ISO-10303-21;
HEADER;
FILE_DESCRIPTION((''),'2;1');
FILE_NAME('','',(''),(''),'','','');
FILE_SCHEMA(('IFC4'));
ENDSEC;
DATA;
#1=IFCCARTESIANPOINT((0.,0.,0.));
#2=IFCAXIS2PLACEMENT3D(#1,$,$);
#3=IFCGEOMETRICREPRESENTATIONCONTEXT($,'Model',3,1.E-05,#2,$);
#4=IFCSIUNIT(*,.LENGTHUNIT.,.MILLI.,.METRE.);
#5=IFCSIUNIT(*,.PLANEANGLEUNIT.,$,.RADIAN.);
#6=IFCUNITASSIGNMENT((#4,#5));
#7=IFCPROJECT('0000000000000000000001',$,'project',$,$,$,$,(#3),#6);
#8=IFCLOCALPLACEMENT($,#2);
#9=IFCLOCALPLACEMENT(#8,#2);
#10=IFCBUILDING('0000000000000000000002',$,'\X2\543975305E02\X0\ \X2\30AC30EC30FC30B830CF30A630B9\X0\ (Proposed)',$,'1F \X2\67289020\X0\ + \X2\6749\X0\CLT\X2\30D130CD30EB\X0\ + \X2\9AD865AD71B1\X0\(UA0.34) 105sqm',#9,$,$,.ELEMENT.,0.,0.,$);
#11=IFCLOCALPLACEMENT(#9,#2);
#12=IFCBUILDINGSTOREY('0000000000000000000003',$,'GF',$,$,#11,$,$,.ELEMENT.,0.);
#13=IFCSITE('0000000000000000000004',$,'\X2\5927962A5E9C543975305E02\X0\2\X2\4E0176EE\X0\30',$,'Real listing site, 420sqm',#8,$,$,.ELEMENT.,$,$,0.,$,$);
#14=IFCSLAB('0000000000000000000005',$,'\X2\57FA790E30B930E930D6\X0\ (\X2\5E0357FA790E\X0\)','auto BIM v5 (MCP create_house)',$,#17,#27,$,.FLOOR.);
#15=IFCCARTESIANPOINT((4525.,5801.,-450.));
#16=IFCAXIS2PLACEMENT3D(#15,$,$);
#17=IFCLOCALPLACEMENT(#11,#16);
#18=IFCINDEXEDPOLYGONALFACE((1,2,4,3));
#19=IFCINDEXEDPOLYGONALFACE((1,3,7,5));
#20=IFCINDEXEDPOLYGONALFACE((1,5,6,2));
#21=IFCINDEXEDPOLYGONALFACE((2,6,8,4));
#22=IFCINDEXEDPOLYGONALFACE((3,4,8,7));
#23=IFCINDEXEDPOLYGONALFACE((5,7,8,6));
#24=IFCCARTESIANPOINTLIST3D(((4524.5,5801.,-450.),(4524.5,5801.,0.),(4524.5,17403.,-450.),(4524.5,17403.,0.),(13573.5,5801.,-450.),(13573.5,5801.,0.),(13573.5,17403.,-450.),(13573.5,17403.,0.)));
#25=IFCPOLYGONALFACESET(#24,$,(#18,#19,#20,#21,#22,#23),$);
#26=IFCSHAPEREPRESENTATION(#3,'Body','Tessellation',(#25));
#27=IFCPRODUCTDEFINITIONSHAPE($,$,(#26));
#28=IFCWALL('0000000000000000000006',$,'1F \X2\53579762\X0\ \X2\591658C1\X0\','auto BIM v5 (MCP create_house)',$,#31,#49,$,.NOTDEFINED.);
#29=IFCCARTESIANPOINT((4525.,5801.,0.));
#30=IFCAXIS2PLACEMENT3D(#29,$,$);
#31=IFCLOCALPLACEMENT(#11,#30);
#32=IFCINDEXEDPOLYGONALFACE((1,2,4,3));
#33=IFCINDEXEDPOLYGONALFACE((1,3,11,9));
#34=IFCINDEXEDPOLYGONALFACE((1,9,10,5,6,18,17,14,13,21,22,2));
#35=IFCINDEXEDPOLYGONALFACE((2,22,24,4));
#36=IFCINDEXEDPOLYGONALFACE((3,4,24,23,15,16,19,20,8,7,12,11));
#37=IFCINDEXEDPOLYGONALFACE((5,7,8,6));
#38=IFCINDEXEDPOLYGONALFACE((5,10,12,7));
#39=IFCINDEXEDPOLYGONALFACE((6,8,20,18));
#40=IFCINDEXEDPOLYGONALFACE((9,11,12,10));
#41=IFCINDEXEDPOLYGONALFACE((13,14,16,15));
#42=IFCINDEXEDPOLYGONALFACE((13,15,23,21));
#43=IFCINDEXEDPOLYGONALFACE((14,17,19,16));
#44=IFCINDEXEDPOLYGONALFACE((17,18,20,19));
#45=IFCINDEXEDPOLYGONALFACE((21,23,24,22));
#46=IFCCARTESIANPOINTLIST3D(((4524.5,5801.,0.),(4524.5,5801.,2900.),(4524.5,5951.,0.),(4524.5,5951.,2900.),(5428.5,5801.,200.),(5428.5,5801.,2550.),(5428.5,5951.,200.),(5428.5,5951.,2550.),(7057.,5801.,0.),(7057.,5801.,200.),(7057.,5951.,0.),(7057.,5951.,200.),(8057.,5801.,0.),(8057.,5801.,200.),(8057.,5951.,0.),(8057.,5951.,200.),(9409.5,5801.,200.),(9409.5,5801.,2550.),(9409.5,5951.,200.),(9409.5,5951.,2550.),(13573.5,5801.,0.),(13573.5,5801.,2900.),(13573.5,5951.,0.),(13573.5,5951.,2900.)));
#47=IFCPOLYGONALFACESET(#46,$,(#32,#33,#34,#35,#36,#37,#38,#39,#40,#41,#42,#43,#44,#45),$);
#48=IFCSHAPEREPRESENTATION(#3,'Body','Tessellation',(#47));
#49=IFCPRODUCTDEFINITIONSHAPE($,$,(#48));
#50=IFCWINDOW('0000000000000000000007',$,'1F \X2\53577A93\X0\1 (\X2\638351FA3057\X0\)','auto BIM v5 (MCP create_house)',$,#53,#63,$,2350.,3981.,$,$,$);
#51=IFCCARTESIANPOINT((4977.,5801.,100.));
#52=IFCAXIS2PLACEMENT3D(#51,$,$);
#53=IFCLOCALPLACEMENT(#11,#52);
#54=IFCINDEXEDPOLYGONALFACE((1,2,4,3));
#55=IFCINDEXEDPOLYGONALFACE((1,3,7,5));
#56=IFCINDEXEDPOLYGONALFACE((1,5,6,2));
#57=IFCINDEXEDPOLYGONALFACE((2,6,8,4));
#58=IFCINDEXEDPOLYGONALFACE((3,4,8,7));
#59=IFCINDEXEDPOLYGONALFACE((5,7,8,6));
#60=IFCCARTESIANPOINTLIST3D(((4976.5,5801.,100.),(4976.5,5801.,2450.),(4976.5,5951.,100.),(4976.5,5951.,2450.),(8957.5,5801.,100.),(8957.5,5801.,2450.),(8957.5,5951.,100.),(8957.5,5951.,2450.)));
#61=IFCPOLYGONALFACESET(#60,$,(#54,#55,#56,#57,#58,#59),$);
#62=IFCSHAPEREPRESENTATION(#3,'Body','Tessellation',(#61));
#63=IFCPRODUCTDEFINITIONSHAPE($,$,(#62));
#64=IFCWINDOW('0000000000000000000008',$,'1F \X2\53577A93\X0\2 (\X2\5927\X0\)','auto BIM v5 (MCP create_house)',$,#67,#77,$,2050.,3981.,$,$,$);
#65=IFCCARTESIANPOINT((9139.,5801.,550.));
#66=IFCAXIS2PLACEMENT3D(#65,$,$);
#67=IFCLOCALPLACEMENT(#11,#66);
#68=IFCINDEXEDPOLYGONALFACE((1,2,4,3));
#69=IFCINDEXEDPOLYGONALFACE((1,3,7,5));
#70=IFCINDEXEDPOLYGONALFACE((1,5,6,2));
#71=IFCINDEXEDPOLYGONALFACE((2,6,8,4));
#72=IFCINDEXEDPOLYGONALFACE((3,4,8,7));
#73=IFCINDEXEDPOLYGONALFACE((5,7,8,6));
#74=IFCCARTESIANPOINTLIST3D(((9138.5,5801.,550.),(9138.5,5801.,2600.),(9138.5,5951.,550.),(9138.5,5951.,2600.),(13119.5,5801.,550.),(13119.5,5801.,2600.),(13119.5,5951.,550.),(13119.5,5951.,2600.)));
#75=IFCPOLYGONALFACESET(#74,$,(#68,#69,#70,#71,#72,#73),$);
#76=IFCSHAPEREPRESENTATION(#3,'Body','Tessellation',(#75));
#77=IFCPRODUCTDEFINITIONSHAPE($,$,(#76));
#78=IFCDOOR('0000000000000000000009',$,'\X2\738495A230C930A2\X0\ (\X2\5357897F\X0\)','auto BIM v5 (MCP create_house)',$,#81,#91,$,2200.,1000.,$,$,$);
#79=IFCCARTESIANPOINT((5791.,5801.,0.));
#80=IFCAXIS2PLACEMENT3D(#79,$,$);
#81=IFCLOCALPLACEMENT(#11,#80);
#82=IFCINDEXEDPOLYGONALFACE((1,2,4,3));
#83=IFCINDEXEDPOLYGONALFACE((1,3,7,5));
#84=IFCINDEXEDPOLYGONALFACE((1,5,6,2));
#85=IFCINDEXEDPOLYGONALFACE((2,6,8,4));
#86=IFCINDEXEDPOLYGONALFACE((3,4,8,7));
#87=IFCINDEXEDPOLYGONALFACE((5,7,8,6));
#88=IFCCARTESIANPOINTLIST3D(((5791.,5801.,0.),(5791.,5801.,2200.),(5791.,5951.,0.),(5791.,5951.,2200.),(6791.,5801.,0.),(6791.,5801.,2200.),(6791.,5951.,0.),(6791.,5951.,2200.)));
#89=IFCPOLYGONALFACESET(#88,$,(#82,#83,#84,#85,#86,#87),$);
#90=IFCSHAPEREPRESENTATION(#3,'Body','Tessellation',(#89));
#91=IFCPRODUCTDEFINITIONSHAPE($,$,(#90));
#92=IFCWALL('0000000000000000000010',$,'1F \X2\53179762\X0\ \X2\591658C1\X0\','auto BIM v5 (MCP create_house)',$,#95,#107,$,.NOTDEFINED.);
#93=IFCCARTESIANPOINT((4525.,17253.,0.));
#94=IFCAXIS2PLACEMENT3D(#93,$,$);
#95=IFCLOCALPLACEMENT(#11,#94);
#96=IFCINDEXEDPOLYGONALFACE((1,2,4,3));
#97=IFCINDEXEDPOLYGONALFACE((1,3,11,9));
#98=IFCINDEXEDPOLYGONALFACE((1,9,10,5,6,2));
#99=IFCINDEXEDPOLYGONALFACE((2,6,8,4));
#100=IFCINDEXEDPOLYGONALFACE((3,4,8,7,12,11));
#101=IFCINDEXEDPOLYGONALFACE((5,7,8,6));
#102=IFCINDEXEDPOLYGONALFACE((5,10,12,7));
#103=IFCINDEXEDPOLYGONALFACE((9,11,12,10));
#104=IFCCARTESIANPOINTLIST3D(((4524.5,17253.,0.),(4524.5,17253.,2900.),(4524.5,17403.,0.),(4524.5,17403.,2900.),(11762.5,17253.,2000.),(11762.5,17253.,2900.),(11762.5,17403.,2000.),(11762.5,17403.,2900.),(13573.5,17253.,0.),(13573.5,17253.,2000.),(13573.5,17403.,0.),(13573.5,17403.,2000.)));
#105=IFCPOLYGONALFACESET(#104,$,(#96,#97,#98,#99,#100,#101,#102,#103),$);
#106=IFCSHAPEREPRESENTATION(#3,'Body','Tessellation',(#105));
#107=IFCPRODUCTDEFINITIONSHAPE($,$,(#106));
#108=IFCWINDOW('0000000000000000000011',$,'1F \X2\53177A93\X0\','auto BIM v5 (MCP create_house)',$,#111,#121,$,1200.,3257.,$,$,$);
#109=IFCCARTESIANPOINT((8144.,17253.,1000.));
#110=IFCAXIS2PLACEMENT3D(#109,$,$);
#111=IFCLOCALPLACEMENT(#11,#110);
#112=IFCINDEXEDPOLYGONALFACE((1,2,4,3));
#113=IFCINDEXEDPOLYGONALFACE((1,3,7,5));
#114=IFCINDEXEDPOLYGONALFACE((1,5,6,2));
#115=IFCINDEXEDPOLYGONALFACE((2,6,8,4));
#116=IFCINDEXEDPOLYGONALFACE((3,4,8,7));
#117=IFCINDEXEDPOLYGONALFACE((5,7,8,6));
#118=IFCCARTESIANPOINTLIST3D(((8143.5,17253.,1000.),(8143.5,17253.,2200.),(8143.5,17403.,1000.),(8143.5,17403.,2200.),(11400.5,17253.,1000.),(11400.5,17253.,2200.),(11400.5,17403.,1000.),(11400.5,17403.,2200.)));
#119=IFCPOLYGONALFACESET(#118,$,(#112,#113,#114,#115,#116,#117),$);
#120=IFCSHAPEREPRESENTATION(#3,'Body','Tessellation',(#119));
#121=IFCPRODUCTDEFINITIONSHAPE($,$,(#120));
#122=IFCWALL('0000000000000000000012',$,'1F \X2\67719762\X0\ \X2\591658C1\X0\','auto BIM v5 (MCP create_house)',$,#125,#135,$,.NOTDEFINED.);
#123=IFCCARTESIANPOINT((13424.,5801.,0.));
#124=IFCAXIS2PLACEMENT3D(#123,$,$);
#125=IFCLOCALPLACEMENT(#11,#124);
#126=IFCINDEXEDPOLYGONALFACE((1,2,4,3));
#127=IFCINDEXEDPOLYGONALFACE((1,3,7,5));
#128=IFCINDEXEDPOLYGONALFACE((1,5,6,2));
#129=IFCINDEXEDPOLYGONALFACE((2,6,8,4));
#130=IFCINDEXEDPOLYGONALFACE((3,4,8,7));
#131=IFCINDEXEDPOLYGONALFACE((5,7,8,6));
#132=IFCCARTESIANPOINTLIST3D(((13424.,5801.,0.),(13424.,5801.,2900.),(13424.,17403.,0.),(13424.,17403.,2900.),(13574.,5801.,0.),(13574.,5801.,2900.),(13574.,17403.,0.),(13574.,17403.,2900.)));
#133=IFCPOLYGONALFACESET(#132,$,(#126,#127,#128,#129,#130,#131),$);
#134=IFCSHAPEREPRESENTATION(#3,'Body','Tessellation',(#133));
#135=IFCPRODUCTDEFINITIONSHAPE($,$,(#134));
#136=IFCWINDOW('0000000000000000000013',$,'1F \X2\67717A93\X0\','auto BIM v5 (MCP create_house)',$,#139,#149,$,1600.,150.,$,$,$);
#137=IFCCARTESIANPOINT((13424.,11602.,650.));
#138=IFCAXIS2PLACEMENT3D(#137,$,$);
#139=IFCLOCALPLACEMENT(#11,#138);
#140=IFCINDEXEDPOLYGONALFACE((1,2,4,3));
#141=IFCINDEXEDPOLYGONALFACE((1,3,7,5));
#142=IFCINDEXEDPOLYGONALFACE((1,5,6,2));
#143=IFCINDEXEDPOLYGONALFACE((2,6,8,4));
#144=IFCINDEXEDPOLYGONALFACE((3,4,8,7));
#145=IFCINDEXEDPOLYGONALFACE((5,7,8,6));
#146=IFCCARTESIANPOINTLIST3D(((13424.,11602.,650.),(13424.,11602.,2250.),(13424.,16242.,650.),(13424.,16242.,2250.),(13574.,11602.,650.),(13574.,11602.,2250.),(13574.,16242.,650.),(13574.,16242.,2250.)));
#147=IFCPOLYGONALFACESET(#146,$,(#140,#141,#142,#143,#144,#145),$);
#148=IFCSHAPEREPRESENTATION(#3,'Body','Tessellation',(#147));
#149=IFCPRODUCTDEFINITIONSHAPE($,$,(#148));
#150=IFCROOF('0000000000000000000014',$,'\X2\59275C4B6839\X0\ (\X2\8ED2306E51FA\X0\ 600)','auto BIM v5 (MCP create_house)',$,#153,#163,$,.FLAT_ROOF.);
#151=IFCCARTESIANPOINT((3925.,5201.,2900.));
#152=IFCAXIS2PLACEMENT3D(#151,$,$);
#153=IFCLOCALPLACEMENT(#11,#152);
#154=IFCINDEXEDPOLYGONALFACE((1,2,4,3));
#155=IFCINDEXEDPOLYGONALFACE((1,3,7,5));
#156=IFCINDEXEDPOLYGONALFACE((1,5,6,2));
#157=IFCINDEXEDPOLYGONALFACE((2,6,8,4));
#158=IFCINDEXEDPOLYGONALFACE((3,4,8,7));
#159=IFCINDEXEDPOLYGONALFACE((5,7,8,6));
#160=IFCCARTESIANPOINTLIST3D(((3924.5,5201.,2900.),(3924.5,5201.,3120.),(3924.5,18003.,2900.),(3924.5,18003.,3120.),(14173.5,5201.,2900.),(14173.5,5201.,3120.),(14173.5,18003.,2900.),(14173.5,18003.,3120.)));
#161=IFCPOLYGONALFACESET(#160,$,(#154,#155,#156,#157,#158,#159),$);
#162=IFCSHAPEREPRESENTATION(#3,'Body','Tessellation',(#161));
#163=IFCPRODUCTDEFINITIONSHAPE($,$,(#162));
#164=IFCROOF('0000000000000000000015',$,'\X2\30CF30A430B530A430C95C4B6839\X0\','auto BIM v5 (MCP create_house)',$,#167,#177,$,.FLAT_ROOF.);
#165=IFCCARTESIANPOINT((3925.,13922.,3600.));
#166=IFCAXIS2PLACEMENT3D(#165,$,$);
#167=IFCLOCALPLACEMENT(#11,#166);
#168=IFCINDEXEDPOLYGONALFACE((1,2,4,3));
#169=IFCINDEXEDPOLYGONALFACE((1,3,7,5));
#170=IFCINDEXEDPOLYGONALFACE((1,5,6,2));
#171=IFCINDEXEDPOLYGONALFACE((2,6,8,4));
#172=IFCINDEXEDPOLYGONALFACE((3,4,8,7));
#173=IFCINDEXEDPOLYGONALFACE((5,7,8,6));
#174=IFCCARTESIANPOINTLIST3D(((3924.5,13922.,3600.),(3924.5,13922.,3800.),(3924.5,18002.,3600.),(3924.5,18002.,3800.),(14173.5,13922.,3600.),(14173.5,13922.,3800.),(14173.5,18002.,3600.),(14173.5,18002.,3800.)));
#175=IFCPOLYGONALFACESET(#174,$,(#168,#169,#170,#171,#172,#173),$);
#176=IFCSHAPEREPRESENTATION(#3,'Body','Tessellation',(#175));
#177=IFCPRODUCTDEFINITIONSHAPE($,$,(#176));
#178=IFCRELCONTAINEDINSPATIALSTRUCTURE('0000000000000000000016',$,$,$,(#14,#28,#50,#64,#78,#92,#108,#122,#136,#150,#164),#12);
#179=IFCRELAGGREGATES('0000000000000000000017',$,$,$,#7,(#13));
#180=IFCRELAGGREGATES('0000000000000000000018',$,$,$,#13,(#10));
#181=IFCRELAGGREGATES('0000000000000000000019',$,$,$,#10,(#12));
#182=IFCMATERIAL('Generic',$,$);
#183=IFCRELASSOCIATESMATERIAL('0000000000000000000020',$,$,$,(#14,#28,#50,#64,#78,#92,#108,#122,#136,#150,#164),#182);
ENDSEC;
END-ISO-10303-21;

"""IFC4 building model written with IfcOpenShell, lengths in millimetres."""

from ifc_helpers import new_model, si_unit, frame, frame_2d, origin, place, context, project, spatial, rectangle, extrude, material, element, fill, save


model = new_model("IFC4")

# Units and contexts
model_context = context("Model", 3, precision=1e-05, world=origin())
ifc_project = project(units=[si_unit("LENGTHUNIT", "METRE", prefix="MILLI"), si_unit("PLANEANGLEUNIT", "RADIAN")], contexts=[model_context])

# Site, building, storey
site_placement = place(None, origin())
site = spatial("IfcSite", under=ifc_project, at=site_placement, Name="大阪府吹田市2丁目30", ObjectType="Real listing site, 420sqm", CompositionType="ELEMENT", RefElevation=0.0)
building_placement = place(site_placement, origin())
building = spatial("IfcBuilding", under=site, at=building_placement, Name="吹田市 ガレージハウス (Proposed)", ObjectType="1F 木造 + 杉CLTパネル + 高断熱(UA0.34) 105sqm", CompositionType="ELEMENT", ElevationOfRefHeight=0.0, ElevationOfTerrain=0.0)
storey_placement = place(building_placement, origin())
storey = spatial("IfcBuildingStorey", under=building, at=storey_placement, Name="GF", CompositionType="ELEMENT", Elevation=0.0)

# Slab
ifc_material = material(Name="Generic")
slab_1_placement = place(storey_placement, frame((4525.0, 5801.0, -450.0)))
element("IfcSlab", 1, at=slab_1_placement, inside=storey, material=ifc_material, Name="基礎スラブ (布基礎)", Description="auto BIM v5 (MCP create_house)", PredefinedType="FLOOR", context=model_context, shape_type="SweptSolid", body=[
    extrude(rectangle(XDim=9049.0, YDim=11602.0, at=frame_2d((4524.0, 5801.0))), frame((4525.0, 5801.0, -450.0)), (0.0, 0.0, 1.0), 450.0),
])

# Wall, openings, windows, door
wall_1_placement = place(storey_placement, frame((4525.0, 5801.0, 0.0)))
wall_1 = element("IfcWall", 2, at=wall_1_placement, inside=storey, material=ifc_material, Name="1F 南面 外壁", Description="auto BIM v5 (MCP create_house)", PredefinedType="NOTDEFINED", context=model_context, shape_type="SweptSolid", body=[
    extrude(rectangle(XDim=9049.0, YDim=150.0, at=frame_2d((4524.0, 75.0))), frame((4525.0, 5801.0, 0.0)), (0.0, 0.0, 1.0), 2900.0),
])
opening_1_placement = place(storey_placement, frame((4977.0, 5801.0, 100.0)))
opening_1 = element("IfcOpeningElement", 3, at=opening_1_placement, cuts=wall_1, PredefinedType="NOTDEFINED", context=model_context, shape_type="SweptSolid", body=[
    extrude(rectangle(XDim=3981.0, YDim=150.0, at=frame_2d((1990.0, 75.0))), frame((4977.0, 5801.0, 100.0)), (0.0, 0.0, 1.0), 2350.0),
])
opening_2_placement = place(storey_placement, frame((9139.0, 5801.0, 550.0)))
opening_2 = element("IfcOpeningElement", 4, at=opening_2_placement, cuts=wall_1, PredefinedType="NOTDEFINED", context=model_context, shape_type="SweptSolid", body=[
    extrude(rectangle(XDim=3981.0, YDim=150.0, at=frame_2d((1990.0, 75.0))), frame((9139.0, 5801.0, 550.0)), (0.0, 0.0, 1.0), 2050.0),
])
opening_3_placement = place(storey_placement, frame((5791.0, 5801.0, 0.0)))
opening_3 = element("IfcOpeningElement", 5, at=opening_3_placement, cuts=wall_1, PredefinedType="NOTDEFINED", context=model_context, shape_type="SweptSolid", body=[
    extrude(rectangle(XDim=1000.0, YDim=150.0, at=frame_2d((500.0, 75.0))), frame((5791.0, 5801.0, 0.0)), (0.0, 0.0, 1.0), 2200.0),
])
window_1_placement = place(storey_placement, frame((4977.0, 5801.0, 100.0)))
window_1 = element("IfcWindow", 6, at=window_1_placement, inside=storey, material=ifc_material, Name="1F 南窓1 (掃出し)", Description="auto BIM v5 (MCP create_house)", OverallHeight=2350.0, OverallWidth=3981.0, context=model_context, shape_type="SweptSolid", body=[
    extrude(rectangle(XDim=3981.0, YDim=150.0, at=frame_2d((1990.0, 75.0))), frame((4977.0, 5801.0, 100.0)), (0.0, 0.0, 1.0), 2350.0),
])
fill(opening_1, window_1)
window_2_placement = place(storey_placement, frame((9139.0, 5801.0, 550.0)))
window_2 = element("IfcWindow", 7, at=window_2_placement, inside=storey, material=ifc_material, Name="1F 南窓2 (大)", Description="auto BIM v5 (MCP create_house)", OverallHeight=2050.0, OverallWidth=3981.0, context=model_context, shape_type="SweptSolid", body=[
    extrude(rectangle(XDim=3981.0, YDim=150.0, at=frame_2d((1990.0, 75.0))), frame((9139.0, 5801.0, 550.0)), (0.0, 0.0, 1.0), 2050.0),
])
fill(opening_2, window_2)
door_placement = place(storey_placement, frame((5791.0, 5801.0, 0.0)))
door = element("IfcDoor", 8, at=door_placement, inside=storey, material=ifc_material, Name="玄関ドア (南西)", Description="auto BIM v5 (MCP create_house)", OverallHeight=2200.0, OverallWidth=1000.0, context=model_context, shape_type="SweptSolid", body=[
    extrude(rectangle(XDim=1000.0, YDim=150.0, at=frame_2d((500.0, 75.0))), frame((5791.0, 5801.0, 0.0)), (0.0, 0.0, 1.0), 2200.0),
])
fill(opening_3, door)

# Walls, openings, windows
wall_2_placement = place(storey_placement, frame((4525.0, 17253.0, 0.0)))
wall_2 = element("IfcWall", 9, at=wall_2_placement, inside=storey, material=ifc_material, Name="1F 北面 外壁", Description="auto BIM v5 (MCP create_house)", PredefinedType="NOTDEFINED", context=model_context, shape_type="SweptSolid", body=[
    extrude(rectangle(XDim=9049.0, YDim=150.0, at=frame_2d((4524.0, 75.0))), frame((4525.0, 17253.0, 0.0)), (0.0, 0.0, 1.0), 2900.0),
])
opening_4_placement = place(storey_placement, frame((8144.0, 17253.0, 1000.0)))
opening_4 = element("IfcOpeningElement", 10, at=opening_4_placement, cuts=wall_2, PredefinedType="NOTDEFINED", context=model_context, shape_type="SweptSolid", body=[
    extrude(rectangle(XDim=3257.0, YDim=150.0, at=frame_2d((1628.0, 75.0))), frame((8144.0, 17253.0, 1000.0)), (0.0, 0.0, 1.0), 1200.0),
])
window_3_placement = place(storey_placement, frame((8144.0, 17253.0, 1000.0)))
window_3 = element("IfcWindow", 11, at=window_3_placement, inside=storey, material=ifc_material, Name="1F 北窓", Description="auto BIM v5 (MCP create_house)", OverallHeight=1200.0, OverallWidth=3257.0, context=model_context, shape_type="SweptSolid", body=[
    extrude(rectangle(XDim=3257.0, YDim=150.0, at=frame_2d((1628.0, 75.0))), frame((8144.0, 17253.0, 1000.0)), (0.0, 0.0, 1.0), 1200.0),
])
fill(opening_4, window_3)
wall_3_placement = place(storey_placement, frame((13424.0, 5801.0, 0.0)))
wall_3 = element("IfcWall", 12, at=wall_3_placement, inside=storey, material=ifc_material, Name="1F 東面 外壁", Description="auto BIM v5 (MCP create_house)", PredefinedType="NOTDEFINED", context=model_context, shape_type="SweptSolid", body=[
    extrude(rectangle(XDim=150.0, YDim=11602.0, at=frame_2d((75.0, 5801.0))), frame((13424.0, 5801.0, 0.0)), (0.0, 0.0, 1.0), 2900.0),
])
opening_5_placement = place(storey_placement, frame((13424.0, 11602.0, 650.0)))
opening_5 = element("IfcOpeningElement", 13, at=opening_5_placement, cuts=wall_3, PredefinedType="NOTDEFINED", context=model_context, shape_type="SweptSolid", body=[
    extrude(rectangle(XDim=150.0, YDim=4640.0, at=frame_2d((75.0, 2320.0))), frame((13424.0, 11602.0, 650.0)), (0.0, 0.0, 1.0), 1600.0),
])
window_4_placement = place(storey_placement, frame((13424.0, 11602.0, 650.0)))
window_4 = element("IfcWindow", 14, at=window_4_placement, inside=storey, material=ifc_material, Name="1F 東窓", Description="auto BIM v5 (MCP create_house)", OverallHeight=1600.0, OverallWidth=150.0, context=model_context, shape_type="SweptSolid", body=[
    extrude(rectangle(XDim=150.0, YDim=4640.0, at=frame_2d((75.0, 2320.0))), frame((13424.0, 11602.0, 650.0)), (0.0, 0.0, 1.0), 1600.0),
])
fill(opening_5, window_4)

# Roofs
roof_1_placement = place(storey_placement, frame((3925.0, 5201.0, 2900.0)))
element("IfcRoof", 15, at=roof_1_placement, inside=storey, material=ifc_material, Name="大屋根 (軒の出 600)", Description="auto BIM v5 (MCP create_house)", PredefinedType="FLAT_ROOF", context=model_context, shape_type="SweptSolid", body=[
    extrude(rectangle(XDim=10249.0, YDim=12802.0, at=frame_2d((5124.0, 6401.0))), frame((3925.0, 5201.0, 2900.0)), (0.0, 0.0, 1.0), 220.0),
])
roof_2_placement = place(storey_placement, frame((3925.0, 13922.0, 3600.0)))
element("IfcRoof", 16, at=roof_2_placement, inside=storey, material=ifc_material, Name="ハイサイド屋根", Description="auto BIM v5 (MCP create_house)", PredefinedType="FLAT_ROOF", context=model_context, shape_type="SweptSolid", body=[
    extrude(rectangle(XDim=10249.0, YDim=4080.0, at=frame_2d((5124.0, 2040.0))), frame((3925.0, 13922.0, 3600.0)), (0.0, 0.0, 1.0), 200.0),
])

save(model, "model.ifc")
